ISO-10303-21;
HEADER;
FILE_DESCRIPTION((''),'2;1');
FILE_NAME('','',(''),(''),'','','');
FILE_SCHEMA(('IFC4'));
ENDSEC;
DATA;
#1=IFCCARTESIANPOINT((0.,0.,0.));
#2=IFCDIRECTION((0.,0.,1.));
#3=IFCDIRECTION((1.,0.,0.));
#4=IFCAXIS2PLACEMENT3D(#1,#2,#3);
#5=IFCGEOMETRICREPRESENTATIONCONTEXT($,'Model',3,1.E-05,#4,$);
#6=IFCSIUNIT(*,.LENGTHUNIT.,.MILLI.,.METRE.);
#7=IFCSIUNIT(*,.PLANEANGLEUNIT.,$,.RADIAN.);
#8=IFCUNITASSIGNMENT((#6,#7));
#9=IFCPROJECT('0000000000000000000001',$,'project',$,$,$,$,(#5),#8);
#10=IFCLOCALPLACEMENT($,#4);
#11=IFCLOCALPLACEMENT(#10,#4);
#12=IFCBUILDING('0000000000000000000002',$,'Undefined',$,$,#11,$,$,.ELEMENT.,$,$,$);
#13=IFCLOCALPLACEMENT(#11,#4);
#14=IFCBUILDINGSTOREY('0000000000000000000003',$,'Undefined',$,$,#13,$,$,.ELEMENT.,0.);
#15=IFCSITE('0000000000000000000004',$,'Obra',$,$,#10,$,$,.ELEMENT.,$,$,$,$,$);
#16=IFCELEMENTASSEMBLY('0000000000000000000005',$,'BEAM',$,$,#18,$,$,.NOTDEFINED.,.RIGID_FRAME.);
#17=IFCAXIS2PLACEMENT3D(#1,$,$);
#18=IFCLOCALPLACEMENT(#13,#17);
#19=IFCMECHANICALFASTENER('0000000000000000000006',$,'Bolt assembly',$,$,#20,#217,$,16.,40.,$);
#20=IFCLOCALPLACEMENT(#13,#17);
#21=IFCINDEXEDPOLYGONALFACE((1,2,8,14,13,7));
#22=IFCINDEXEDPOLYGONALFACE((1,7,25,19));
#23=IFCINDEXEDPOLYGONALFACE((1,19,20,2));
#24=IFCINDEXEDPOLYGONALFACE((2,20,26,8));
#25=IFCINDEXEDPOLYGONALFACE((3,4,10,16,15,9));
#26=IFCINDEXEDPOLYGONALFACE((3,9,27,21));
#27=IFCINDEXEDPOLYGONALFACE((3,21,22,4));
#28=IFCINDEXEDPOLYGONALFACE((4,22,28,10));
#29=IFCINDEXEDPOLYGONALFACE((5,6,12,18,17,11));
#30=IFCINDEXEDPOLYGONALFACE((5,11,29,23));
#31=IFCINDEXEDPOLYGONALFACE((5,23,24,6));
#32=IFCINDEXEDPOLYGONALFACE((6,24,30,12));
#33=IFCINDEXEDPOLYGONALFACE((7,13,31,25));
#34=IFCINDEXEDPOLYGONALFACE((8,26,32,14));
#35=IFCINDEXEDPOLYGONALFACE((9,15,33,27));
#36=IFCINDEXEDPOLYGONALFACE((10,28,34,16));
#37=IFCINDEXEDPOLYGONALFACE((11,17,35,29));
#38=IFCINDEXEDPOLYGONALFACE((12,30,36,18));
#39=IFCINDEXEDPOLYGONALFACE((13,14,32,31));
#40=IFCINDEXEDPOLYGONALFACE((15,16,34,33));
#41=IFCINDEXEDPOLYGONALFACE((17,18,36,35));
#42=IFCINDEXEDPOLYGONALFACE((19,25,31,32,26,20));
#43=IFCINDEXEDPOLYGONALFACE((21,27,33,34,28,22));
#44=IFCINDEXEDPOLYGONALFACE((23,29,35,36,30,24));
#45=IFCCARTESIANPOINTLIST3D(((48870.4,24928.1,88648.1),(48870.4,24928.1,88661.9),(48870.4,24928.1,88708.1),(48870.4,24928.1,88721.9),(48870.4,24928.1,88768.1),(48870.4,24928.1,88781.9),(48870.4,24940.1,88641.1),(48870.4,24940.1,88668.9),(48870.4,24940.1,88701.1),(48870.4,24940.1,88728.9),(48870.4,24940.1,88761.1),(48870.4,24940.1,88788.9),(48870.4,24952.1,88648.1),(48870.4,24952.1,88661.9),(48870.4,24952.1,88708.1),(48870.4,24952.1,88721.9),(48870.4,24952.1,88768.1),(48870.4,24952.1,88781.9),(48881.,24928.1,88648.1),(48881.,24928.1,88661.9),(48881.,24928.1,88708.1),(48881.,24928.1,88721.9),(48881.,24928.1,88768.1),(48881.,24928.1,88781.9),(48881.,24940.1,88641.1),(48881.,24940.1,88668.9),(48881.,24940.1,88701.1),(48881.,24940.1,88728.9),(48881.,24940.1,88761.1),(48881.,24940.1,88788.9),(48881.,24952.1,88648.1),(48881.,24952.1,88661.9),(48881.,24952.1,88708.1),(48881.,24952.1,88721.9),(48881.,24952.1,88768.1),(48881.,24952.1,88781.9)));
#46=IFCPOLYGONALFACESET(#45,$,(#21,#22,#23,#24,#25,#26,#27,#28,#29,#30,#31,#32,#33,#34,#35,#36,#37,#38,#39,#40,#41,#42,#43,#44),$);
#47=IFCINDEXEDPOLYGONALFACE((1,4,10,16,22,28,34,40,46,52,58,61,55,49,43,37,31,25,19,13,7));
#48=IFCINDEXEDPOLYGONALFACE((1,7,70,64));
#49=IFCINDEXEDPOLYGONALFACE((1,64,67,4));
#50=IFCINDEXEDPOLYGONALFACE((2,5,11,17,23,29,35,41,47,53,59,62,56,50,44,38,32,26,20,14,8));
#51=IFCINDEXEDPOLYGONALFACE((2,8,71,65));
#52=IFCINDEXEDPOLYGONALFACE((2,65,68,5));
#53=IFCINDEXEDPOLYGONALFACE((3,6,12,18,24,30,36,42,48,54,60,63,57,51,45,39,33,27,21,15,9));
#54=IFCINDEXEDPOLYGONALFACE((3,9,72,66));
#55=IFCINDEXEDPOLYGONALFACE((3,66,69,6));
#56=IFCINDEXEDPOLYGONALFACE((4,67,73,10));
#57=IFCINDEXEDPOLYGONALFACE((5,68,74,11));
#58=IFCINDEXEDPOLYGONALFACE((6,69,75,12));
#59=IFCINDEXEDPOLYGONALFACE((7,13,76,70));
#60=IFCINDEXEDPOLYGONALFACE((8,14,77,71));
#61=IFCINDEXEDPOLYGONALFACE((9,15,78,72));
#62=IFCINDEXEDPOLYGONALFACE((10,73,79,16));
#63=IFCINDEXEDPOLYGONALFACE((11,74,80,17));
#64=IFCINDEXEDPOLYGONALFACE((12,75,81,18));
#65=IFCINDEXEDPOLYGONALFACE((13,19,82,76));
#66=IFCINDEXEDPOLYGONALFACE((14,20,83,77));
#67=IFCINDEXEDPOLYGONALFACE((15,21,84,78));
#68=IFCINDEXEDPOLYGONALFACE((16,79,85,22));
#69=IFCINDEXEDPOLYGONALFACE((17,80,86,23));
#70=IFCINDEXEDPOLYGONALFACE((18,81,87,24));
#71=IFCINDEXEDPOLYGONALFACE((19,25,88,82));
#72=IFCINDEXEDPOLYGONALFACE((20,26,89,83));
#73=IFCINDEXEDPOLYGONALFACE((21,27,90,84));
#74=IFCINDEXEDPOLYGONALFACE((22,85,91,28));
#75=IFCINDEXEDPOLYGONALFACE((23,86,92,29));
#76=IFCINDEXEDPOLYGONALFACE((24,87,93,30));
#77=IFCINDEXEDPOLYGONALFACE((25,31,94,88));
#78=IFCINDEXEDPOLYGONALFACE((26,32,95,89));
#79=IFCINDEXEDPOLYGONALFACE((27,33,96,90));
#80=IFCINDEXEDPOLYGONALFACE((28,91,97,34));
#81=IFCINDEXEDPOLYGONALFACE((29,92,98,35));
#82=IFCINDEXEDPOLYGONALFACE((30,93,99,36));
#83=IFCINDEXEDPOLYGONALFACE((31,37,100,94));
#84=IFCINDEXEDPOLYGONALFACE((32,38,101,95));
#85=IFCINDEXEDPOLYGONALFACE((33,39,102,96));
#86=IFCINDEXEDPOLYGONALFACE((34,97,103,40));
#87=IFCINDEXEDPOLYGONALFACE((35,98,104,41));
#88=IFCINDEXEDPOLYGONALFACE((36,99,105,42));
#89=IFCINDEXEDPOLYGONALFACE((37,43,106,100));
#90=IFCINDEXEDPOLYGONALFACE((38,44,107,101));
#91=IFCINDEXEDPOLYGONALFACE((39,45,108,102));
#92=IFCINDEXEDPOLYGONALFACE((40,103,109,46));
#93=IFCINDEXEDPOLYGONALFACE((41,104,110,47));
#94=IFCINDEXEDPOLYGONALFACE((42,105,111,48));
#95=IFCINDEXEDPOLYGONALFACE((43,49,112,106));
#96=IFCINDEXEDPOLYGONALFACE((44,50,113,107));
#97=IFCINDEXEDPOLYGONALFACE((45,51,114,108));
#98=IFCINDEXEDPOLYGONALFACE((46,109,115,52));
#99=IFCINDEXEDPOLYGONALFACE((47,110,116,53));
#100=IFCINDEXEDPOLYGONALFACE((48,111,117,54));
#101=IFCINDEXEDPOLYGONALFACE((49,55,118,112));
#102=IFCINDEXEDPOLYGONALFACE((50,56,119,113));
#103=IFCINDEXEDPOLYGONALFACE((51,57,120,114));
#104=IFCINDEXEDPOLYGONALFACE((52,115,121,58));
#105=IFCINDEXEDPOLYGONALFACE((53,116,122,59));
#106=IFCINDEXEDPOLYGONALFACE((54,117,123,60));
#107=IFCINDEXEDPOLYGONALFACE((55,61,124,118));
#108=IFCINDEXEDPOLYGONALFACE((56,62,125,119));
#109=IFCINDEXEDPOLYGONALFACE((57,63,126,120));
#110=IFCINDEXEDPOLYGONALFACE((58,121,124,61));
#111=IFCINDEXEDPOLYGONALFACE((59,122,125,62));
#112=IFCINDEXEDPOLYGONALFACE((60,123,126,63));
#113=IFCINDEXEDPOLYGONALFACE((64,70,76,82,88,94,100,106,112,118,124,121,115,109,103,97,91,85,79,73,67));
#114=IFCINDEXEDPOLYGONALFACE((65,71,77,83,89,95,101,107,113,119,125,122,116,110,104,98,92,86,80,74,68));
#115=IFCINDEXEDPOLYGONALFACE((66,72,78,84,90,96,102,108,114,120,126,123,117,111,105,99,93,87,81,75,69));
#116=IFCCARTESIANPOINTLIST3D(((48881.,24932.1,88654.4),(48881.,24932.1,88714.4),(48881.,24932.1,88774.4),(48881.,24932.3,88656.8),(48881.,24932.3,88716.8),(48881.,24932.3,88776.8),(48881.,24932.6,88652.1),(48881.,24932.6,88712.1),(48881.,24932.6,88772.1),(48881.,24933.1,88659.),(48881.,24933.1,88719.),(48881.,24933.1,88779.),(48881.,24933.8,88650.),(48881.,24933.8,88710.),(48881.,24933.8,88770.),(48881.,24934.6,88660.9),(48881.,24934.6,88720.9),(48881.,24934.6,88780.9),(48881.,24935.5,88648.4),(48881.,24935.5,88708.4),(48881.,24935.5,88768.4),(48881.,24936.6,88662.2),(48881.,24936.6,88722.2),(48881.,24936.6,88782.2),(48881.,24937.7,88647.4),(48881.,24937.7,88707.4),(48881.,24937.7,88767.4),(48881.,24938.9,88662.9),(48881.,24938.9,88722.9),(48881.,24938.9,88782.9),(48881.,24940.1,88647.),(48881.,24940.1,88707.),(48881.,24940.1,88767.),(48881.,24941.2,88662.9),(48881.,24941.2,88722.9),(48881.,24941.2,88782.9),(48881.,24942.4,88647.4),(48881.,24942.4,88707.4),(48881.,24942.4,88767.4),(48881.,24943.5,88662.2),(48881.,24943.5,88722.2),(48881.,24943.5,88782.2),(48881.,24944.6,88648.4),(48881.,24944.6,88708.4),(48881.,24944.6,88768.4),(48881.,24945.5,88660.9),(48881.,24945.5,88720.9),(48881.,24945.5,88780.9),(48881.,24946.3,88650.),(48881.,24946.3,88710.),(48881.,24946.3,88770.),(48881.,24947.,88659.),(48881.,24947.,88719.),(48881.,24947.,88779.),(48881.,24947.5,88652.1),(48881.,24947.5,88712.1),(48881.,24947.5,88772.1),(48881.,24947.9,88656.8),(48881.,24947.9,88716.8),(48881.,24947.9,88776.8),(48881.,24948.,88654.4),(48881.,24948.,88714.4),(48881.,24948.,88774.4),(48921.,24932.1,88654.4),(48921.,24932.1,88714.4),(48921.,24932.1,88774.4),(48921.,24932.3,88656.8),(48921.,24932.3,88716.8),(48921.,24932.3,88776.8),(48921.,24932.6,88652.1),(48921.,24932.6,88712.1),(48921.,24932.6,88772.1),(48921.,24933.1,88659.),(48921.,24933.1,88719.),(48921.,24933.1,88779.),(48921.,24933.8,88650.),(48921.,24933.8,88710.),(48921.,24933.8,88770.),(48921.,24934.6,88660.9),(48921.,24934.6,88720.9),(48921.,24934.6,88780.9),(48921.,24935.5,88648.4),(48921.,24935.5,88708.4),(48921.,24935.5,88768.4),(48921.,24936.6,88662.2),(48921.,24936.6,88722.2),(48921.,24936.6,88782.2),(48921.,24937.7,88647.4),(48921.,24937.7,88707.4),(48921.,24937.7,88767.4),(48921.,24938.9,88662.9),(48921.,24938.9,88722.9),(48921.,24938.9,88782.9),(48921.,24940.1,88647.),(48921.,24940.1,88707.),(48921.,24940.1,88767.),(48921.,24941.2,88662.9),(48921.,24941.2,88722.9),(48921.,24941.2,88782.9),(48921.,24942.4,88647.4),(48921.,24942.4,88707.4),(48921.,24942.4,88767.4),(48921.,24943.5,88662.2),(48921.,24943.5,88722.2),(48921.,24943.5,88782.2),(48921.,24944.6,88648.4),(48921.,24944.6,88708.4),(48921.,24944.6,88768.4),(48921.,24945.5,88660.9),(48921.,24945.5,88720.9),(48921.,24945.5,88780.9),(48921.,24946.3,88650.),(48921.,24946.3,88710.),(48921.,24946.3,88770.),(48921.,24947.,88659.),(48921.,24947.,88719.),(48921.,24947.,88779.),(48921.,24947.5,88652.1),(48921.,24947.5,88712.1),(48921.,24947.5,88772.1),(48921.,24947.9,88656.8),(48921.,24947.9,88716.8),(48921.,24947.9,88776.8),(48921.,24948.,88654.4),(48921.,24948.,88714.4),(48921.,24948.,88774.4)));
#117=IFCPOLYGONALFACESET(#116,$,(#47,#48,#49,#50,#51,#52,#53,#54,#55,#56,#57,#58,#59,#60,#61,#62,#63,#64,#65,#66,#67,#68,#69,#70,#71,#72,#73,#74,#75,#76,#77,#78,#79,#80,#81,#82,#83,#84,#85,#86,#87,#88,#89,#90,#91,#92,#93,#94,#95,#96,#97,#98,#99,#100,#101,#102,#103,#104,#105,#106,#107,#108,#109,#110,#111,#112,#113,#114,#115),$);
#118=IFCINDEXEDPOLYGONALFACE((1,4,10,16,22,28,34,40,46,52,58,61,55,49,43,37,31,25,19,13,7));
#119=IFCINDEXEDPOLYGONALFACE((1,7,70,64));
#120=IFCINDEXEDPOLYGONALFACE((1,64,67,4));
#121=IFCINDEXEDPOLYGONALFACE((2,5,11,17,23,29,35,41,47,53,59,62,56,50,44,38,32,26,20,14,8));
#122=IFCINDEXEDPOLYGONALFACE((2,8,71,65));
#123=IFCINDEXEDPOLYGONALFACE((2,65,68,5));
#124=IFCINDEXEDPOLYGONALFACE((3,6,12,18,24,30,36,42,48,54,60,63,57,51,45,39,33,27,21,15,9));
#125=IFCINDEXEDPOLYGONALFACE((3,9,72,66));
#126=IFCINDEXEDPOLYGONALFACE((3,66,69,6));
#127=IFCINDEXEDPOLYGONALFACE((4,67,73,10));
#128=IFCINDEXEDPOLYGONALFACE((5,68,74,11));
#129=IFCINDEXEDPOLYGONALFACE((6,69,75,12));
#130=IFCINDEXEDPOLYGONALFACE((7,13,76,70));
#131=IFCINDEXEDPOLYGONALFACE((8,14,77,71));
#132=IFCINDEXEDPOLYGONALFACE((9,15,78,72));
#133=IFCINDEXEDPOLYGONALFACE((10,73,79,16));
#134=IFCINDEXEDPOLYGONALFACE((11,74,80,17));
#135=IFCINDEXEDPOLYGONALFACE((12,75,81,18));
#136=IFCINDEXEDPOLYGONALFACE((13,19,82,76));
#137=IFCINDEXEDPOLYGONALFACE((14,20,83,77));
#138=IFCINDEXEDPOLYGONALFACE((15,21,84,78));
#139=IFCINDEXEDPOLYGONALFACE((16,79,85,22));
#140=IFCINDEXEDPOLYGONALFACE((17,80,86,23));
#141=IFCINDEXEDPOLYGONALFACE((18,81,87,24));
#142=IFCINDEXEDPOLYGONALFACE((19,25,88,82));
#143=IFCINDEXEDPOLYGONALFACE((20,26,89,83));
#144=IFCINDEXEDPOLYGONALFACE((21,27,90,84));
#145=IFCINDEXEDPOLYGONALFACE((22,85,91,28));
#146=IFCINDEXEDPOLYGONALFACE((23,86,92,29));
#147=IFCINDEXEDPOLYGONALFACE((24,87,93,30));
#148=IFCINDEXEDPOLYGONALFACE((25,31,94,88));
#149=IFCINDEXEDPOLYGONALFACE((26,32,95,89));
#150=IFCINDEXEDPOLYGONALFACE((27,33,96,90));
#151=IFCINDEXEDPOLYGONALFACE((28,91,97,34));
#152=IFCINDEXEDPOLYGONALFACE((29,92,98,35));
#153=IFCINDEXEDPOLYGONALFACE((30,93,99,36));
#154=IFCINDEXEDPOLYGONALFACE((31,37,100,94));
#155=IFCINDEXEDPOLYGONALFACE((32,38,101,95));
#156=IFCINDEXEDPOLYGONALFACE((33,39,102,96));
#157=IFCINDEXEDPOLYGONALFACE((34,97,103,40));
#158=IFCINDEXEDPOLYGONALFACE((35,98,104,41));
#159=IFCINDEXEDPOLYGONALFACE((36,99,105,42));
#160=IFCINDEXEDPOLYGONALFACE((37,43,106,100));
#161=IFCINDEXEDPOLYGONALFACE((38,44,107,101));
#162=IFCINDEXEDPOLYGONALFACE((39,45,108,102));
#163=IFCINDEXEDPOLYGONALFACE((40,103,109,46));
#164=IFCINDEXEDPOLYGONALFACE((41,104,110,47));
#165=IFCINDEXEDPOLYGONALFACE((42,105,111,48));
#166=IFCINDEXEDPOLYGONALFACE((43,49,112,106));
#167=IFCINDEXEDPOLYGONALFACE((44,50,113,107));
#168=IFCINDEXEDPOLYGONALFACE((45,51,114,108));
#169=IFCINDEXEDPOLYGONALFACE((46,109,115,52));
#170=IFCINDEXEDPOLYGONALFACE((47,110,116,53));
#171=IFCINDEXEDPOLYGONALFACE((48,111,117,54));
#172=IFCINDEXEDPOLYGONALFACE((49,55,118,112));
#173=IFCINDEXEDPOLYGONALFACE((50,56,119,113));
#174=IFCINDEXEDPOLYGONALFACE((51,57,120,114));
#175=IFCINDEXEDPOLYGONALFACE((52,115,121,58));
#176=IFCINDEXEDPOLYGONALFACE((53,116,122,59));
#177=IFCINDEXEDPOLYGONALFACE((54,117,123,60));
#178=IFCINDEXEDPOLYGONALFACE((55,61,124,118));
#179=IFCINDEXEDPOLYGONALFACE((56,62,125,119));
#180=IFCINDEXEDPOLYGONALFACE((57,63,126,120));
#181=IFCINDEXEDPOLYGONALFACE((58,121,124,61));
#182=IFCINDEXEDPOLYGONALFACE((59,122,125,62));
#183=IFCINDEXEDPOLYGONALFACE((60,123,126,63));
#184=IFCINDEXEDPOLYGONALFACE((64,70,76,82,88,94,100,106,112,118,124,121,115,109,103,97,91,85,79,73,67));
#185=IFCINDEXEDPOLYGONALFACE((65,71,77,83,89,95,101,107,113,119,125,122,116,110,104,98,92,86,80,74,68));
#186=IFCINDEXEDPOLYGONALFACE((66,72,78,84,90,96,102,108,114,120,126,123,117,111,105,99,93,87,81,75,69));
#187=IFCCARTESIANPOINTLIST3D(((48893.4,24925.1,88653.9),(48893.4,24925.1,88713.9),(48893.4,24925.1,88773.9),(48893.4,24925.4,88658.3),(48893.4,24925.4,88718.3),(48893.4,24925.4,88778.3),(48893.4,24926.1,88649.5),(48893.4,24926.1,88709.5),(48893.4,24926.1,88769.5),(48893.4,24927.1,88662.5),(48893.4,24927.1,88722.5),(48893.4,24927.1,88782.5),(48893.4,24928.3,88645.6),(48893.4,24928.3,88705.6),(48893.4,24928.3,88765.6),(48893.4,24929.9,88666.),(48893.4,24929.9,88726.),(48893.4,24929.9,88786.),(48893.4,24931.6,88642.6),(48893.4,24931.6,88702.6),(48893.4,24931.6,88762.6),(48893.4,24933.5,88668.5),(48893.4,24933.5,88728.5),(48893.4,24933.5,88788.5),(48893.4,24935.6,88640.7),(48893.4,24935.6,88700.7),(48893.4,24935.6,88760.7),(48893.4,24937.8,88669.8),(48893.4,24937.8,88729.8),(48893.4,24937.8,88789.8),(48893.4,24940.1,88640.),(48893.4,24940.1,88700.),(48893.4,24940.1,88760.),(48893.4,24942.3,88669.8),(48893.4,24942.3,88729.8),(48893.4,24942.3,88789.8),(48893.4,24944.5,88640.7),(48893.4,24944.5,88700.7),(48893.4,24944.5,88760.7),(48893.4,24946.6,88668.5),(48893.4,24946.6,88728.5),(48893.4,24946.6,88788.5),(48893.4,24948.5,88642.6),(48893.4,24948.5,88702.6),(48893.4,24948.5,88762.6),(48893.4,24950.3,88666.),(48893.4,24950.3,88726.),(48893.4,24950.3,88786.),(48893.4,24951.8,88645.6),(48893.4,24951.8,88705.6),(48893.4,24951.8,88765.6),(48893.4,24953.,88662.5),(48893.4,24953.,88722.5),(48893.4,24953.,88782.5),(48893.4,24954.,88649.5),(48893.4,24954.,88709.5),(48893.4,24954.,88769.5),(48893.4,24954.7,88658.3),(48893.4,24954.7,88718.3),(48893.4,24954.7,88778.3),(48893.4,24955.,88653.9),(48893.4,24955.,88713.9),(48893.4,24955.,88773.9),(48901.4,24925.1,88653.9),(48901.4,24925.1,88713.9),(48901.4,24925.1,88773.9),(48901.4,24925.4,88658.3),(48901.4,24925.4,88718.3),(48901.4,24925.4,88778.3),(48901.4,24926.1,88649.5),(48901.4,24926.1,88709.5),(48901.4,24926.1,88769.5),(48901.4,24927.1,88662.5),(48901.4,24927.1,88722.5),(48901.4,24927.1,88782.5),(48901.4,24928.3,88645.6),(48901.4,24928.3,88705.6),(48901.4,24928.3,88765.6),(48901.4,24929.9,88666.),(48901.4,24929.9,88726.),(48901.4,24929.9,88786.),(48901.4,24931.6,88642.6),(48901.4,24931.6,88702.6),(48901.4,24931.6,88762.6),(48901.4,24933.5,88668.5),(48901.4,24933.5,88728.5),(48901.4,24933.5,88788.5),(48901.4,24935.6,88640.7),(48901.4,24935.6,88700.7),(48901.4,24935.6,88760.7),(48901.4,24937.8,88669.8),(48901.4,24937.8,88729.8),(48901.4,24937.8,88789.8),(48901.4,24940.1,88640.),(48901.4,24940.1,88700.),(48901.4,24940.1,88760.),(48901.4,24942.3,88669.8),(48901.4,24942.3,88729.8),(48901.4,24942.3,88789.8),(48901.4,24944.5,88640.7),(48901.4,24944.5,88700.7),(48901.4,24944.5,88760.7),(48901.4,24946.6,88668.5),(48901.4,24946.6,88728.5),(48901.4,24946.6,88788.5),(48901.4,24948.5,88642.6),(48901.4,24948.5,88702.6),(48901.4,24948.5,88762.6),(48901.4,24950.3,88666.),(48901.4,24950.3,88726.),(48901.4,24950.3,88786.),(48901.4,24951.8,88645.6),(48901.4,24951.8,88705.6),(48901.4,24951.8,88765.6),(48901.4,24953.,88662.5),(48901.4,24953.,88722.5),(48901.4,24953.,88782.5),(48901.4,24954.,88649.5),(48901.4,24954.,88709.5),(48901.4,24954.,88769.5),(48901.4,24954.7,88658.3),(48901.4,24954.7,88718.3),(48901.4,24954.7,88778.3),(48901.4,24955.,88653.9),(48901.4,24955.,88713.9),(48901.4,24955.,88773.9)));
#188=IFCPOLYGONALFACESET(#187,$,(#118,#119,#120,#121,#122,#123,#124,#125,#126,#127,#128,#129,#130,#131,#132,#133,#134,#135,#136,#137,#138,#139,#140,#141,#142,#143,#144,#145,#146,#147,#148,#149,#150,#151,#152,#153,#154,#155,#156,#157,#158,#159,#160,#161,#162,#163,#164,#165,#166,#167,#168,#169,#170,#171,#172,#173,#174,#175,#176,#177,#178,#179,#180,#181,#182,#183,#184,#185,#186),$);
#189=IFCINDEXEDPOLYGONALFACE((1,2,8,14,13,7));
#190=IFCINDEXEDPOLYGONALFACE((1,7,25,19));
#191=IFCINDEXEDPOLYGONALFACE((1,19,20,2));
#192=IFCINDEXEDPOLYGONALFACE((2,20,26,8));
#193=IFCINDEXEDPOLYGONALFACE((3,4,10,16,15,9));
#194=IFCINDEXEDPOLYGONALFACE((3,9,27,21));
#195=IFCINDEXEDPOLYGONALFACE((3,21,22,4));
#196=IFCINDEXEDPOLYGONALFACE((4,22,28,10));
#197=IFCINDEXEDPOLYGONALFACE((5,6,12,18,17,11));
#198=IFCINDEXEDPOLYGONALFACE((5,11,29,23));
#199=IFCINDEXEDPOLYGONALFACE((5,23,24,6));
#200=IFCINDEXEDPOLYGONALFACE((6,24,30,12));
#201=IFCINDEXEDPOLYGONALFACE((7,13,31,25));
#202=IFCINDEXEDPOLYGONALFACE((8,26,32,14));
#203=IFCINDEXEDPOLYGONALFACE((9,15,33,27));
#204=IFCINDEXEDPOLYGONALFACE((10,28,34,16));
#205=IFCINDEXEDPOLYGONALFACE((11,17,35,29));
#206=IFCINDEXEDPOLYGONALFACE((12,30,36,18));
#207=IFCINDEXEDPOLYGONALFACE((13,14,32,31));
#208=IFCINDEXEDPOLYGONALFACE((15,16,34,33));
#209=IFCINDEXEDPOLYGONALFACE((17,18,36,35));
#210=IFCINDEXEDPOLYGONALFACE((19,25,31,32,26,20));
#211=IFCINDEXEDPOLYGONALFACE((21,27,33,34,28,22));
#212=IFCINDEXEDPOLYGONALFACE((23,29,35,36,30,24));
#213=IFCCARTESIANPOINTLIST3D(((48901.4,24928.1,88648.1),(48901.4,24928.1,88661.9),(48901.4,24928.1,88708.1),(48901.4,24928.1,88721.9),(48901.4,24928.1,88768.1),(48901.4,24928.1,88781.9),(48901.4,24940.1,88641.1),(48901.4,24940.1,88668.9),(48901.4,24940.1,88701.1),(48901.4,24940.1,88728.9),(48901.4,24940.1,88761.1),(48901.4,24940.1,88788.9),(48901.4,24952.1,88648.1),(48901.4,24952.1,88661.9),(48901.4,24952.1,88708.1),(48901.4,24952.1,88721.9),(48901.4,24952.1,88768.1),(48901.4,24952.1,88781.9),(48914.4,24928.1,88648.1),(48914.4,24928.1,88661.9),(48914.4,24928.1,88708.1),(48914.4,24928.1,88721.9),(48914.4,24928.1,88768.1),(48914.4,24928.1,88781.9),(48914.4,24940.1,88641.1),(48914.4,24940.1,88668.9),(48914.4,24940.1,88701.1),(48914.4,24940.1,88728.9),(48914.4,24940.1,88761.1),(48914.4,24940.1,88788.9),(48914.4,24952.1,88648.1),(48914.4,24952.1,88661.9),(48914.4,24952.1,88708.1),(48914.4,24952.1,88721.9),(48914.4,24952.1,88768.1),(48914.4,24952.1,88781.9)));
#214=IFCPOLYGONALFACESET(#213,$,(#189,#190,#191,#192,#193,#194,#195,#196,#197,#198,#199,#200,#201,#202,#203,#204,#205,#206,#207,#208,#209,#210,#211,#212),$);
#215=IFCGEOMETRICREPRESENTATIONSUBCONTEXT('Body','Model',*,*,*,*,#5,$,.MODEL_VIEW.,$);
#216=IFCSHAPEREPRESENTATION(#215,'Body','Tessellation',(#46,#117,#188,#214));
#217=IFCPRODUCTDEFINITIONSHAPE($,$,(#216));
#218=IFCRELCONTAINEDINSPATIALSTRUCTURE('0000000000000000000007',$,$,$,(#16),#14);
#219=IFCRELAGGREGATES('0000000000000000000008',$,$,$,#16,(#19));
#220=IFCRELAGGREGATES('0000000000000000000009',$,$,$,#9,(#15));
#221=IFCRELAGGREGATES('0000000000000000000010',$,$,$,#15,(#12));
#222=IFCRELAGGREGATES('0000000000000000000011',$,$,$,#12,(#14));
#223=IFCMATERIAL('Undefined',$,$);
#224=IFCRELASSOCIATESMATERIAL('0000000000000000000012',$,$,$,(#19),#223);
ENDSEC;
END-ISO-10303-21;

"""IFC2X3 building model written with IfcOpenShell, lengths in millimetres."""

from ifc_helpers import new_model, si_unit, frame, origin_with_axes, origin_2d_with_axis, place, context, subcontext, project, spatial, polyline, circle, outline, extrude, source, transform, mapped, material, element, aggregate, save


model = new_model("IFC2X3")

# Units and contexts
model_context = context("Model", 3, precision=1e-05, world=origin_with_axes())
body_context = subcontext(model_context, "Body", "Model", "MODEL_VIEW")
ifc_project = project(units=[si_unit("LENGTHUNIT", "METRE", prefix="MILLI"), si_unit("PLANEANGLEUNIT", "RADIAN")], contexts=[model_context])

# Site, building, storey
site_placement = place(None, origin_with_axes())
site = spatial("IfcSite", under=ifc_project, at=site_placement, Name="Obra", CompositionType="ELEMENT")
building_placement = place(site_placement, origin_with_axes())
building = spatial("IfcBuilding", under=site, at=building_placement, Name="Undefined", CompositionType="ELEMENT")
storey_placement = place(building_placement, origin_with_axes())
storey = spatial("IfcBuildingStorey", under=building, at=storey_placement, Name="Undefined", CompositionType="ELEMENT", Elevation=0.0)

# Element assembly, mechanical fastener
ifc_material_1 = material(Name="Undefined")
assembly_1_placement = place(storey_placement, origin_with_axes())
assembly_1 = element("IfcElementAssembly", 1, at=assembly_1_placement, inside=storey, Name="BEAM", AssemblyPlace="NOTDEFINED", PredefinedType="RIGID_FRAME")
shared_shape_1 = source(origin_with_axes(), body_context, "Body", "SweptSolid", [
    extrude(outline(polyline([(13.9, 0.0), (6.9, 12.0), (-6.9, 12.0), (-13.9, 0.0), (-6.9, -12.0), (6.9, -12.0), (13.9, 0.0)])), frame((0.0, -19.7, 0.0), z_axis=(0.0, 1.0, 0.0), x_axis=(1.0, 0.0, 0.0)), (0.0, 0.0, 1.0), 10.6),
    extrude(circle(Radius=8.0, at=origin_2d_with_axis()), frame((0.0, -9.1, 0.0), z_axis=(0.0, 1.0, 0.0), x_axis=(1.0, 0.0, 0.0)), (0.0, 0.0, 1.0), 40.0),
    extrude(circle(Radius=15.0, at=origin_2d_with_axis()), frame((0.0, 3.3, 0.0), z_axis=(0.0, 1.0, 0.0), x_axis=(1.0, 0.0, 0.0)), (0.0, 0.0, 1.0), 8.0),
    extrude(outline(polyline([(13.9, 0.0), (6.9, 12.0), (-6.9, 12.0), (-13.9, 0.0), (-6.9, -12.0), (6.9, -12.0), (13.9, 0.0)])), frame((0.0, 11.3, 0.0), z_axis=(0.0, 1.0, 0.0), x_axis=(1.0, 0.0, 0.0)), (0.0, 0.0, 1.0), 13.0),
])
mechanical_fastener_1_placement = place(assembly_1_placement, frame((48890.1, 24990.1, 88835.0), z_axis=(0.000002, -1.0, 0.0), x_axis=(0.0, 0.0, -1.0)))
mechanical_fastener_1 = element("IfcMechanicalFastener", 2, at=mechanical_fastener_1_placement, material=ifc_material_1, Name="Bolt assembly", NominalDiameter=16.0, NominalLength=40.0, context=body_context, shape_type="MappedRepresentation", body=[
    mapped(shared_shape_1, transform((60.0, 0.0, 50.0))),
    mapped(shared_shape_1, transform((120.0, 0.0, 50.0))),
    mapped(shared_shape_1, transform((180.0, 0.0, 50.0))),
])

aggregate(assembly_1, [mechanical_fastener_1])

save(model, "model.ifc")
